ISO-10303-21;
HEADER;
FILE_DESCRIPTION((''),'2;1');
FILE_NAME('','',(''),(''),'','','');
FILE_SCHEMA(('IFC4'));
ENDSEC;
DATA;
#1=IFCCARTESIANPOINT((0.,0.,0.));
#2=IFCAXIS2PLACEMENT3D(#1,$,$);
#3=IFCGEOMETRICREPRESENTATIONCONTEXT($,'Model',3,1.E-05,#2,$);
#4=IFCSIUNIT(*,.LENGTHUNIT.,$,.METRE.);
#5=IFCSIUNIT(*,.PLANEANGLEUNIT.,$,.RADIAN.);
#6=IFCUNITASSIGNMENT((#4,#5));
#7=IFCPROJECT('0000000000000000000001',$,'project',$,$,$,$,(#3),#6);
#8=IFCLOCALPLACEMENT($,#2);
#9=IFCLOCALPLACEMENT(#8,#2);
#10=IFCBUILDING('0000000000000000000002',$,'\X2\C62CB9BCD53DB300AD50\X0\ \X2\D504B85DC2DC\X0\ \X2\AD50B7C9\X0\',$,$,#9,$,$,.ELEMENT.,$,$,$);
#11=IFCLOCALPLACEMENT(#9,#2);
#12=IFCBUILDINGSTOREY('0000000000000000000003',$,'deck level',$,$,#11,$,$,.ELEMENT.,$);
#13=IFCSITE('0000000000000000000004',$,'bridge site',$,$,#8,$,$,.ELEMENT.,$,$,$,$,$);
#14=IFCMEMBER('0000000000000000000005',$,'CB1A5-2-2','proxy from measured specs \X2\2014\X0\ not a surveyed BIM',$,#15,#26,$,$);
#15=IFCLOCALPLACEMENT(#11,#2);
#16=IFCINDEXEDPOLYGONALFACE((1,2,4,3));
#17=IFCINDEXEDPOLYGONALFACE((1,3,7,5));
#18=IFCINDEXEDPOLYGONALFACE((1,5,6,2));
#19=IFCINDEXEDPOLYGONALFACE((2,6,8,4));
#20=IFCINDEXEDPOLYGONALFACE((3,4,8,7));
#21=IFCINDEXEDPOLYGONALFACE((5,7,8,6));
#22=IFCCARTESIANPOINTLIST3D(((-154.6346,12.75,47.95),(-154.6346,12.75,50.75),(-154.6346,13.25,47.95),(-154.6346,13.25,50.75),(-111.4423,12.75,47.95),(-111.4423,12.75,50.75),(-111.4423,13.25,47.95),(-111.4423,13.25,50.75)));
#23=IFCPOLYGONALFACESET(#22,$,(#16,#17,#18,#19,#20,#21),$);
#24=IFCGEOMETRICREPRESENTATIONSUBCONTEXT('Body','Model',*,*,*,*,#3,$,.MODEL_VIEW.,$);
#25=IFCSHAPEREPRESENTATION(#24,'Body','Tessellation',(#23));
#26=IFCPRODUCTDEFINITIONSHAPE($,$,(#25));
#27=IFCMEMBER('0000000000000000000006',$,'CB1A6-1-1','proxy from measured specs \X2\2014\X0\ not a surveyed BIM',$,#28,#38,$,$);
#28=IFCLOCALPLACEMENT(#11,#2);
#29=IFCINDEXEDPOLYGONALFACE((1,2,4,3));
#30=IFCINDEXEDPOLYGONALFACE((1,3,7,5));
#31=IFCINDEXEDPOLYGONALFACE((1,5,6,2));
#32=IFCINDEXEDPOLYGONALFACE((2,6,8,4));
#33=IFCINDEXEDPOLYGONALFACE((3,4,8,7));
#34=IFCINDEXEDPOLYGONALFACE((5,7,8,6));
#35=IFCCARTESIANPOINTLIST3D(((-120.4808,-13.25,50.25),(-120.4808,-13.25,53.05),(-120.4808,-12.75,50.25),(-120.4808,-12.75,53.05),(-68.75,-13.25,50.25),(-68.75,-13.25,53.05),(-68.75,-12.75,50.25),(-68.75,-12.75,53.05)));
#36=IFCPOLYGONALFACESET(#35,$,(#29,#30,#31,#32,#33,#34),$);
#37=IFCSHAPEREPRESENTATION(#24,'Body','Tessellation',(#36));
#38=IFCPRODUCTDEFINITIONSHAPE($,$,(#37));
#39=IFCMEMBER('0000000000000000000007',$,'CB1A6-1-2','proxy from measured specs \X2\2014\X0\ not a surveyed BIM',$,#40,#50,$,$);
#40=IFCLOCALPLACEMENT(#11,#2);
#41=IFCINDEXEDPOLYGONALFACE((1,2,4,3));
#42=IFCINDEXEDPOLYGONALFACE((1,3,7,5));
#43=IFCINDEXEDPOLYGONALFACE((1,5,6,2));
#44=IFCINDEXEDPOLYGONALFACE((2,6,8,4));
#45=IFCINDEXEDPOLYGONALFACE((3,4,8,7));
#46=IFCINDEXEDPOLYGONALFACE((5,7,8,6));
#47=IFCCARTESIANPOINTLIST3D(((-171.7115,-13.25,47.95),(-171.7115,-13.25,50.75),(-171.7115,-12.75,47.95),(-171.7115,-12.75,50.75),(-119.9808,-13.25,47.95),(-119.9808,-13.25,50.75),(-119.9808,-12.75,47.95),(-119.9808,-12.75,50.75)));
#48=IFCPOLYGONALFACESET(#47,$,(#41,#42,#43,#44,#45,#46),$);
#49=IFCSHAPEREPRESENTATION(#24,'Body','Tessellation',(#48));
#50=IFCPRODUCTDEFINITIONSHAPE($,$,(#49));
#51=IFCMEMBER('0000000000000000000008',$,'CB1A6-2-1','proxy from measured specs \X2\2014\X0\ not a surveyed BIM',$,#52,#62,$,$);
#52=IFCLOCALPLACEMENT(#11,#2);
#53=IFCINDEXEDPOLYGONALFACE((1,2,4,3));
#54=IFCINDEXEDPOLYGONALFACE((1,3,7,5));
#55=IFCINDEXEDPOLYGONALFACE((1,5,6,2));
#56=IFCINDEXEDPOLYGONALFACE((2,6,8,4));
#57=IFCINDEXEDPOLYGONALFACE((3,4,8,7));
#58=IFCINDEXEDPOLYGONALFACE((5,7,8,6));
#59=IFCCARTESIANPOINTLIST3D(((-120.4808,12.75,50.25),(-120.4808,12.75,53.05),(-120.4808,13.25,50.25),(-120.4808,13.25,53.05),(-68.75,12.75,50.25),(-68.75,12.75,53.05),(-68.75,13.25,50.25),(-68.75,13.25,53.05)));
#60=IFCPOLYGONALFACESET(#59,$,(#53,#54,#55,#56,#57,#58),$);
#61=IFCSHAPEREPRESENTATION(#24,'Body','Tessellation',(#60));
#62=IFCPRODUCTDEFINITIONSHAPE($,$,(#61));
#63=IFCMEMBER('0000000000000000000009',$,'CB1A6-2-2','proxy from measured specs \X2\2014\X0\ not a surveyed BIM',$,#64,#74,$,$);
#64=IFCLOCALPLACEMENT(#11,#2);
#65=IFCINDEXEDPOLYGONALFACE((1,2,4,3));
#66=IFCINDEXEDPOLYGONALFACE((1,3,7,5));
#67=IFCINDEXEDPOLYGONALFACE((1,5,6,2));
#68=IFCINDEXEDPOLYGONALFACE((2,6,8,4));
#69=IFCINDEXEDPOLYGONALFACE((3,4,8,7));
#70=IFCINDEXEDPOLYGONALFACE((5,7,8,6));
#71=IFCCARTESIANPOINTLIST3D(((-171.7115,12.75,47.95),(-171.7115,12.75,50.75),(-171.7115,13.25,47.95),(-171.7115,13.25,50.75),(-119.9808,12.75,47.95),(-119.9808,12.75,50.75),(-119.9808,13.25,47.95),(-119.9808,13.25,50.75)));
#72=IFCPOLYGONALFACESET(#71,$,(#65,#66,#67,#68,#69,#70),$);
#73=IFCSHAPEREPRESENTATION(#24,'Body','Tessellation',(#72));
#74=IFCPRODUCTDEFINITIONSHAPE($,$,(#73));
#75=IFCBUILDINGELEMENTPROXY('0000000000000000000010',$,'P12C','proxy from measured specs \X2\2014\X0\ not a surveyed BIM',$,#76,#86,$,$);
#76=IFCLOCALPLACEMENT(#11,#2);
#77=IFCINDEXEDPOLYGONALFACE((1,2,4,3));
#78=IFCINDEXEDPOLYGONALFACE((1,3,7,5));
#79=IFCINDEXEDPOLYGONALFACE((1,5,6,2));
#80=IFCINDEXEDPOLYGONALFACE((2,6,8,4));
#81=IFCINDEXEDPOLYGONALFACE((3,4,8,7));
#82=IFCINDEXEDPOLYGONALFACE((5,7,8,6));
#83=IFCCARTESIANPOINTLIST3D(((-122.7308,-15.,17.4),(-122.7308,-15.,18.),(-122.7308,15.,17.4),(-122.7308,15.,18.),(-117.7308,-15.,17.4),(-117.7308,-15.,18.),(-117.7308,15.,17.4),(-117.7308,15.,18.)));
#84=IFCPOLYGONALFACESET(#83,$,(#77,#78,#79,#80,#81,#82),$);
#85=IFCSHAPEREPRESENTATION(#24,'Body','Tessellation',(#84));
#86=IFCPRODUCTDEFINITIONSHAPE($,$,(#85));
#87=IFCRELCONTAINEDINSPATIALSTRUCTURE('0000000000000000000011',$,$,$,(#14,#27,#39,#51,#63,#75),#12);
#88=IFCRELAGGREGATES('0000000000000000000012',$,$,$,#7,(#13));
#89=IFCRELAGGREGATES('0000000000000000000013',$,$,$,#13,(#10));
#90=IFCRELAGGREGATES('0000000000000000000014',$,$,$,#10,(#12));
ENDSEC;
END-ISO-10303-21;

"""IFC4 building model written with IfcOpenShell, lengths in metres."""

from ifc_helpers import new_model, si_unit, frame, origin, origin_2d, place, context, subcontext, project, spatial, rectangle, extrude, element, save


model = new_model("IFC4")

# Units and contexts
model_context = context("Model", 3, precision=1e-05, world=origin())
body_context = subcontext(model_context, "Body", "Model", "MODEL_VIEW")
ifc_project = project(units=[si_unit("LENGTHUNIT", "METRE"), si_unit("PLANEANGLEUNIT", "RADIAN")], contexts=[model_context])

# Site, building, storey
site_placement = place(None, origin())
site = spatial("IfcSite", under=ifc_project, at=site_placement, Name="bridge site", CompositionType="ELEMENT")
building_placement = place(site_placement, origin())
building = spatial("IfcBuilding", under=site, at=building_placement, Name="올림픽대교 프록시 교량", CompositionType="ELEMENT")
storey_placement = place(building_placement, origin())
storey = spatial("IfcBuildingStorey", under=building, at=storey_placement, Name="deck level", CompositionType="ELEMENT")

# Members
member_1_placement = place(storey_placement, frame((-133.0385, 13.0, 47.95)))
element("IfcMember", 1, at=member_1_placement, inside=storey, Name="CB1A5-2-2", Description="proxy from measured specs — not a surveyed BIM", context=body_context, shape_type="SweptSolid", body=[
    extrude(rectangle(XDim=43.1923, YDim=0.5, at=origin_2d()), origin(), (0.0, 0.0, 1.0), 2.8),
])
member_2_placement = place(storey_placement, frame((-94.6154, -13.0, 50.25)))
element("IfcMember", 2, at=member_2_placement, inside=storey, Name="CB1A6-1-1", Description="proxy from measured specs — not a surveyed BIM", context=body_context, shape_type="SweptSolid", body=[
    extrude(rectangle(XDim=51.7308, YDim=0.5, at=origin_2d()), origin(), (0.0, 0.0, 1.0), 2.8),
])
member_3_placement = place(storey_placement, frame((-145.8462, -13.0, 47.95)))
element("IfcMember", 3, at=member_3_placement, inside=storey, Name="CB1A6-1-2", Description="proxy from measured specs — not a surveyed BIM", context=body_context, shape_type="SweptSolid", body=[
    extrude(rectangle(XDim=51.7308, YDim=0.5, at=origin_2d()), origin(), (0.0, 0.0, 1.0), 2.8),
])
member_4_placement = place(storey_placement, frame((-94.6154, 13.0, 50.25)))
element("IfcMember", 4, at=member_4_placement, inside=storey, Name="CB1A6-2-1", Description="proxy from measured specs — not a surveyed BIM", context=body_context, shape_type="SweptSolid", body=[
    extrude(rectangle(XDim=51.7308, YDim=0.5, at=origin_2d()), origin(), (0.0, 0.0, 1.0), 2.8),
])
member_5_placement = place(storey_placement, frame((-145.8462, 13.0, 47.95)))
element("IfcMember", 5, at=member_5_placement, inside=storey, Name="CB1A6-2-2", Description="proxy from measured specs — not a surveyed BIM", context=body_context, shape_type="SweptSolid", body=[
    extrude(rectangle(XDim=51.7308, YDim=0.5, at=origin_2d()), origin(), (0.0, 0.0, 1.0), 2.8),
])

# Building element proxy
proxy_placement = place(storey_placement, frame((-120.2308, 0.0, 17.4)))
element("IfcBuildingElementProxy", 6, at=proxy_placement, inside=storey, Name="P12C", Description="proxy from measured specs — not a surveyed BIM", context=body_context, shape_type="SweptSolid", body=[
    extrude(rectangle(XDim=5.0, YDim=30.0, at=origin_2d()), origin(), (0.0, 0.0, 1.0), 0.6),
])

save(model, "model.ifc")
